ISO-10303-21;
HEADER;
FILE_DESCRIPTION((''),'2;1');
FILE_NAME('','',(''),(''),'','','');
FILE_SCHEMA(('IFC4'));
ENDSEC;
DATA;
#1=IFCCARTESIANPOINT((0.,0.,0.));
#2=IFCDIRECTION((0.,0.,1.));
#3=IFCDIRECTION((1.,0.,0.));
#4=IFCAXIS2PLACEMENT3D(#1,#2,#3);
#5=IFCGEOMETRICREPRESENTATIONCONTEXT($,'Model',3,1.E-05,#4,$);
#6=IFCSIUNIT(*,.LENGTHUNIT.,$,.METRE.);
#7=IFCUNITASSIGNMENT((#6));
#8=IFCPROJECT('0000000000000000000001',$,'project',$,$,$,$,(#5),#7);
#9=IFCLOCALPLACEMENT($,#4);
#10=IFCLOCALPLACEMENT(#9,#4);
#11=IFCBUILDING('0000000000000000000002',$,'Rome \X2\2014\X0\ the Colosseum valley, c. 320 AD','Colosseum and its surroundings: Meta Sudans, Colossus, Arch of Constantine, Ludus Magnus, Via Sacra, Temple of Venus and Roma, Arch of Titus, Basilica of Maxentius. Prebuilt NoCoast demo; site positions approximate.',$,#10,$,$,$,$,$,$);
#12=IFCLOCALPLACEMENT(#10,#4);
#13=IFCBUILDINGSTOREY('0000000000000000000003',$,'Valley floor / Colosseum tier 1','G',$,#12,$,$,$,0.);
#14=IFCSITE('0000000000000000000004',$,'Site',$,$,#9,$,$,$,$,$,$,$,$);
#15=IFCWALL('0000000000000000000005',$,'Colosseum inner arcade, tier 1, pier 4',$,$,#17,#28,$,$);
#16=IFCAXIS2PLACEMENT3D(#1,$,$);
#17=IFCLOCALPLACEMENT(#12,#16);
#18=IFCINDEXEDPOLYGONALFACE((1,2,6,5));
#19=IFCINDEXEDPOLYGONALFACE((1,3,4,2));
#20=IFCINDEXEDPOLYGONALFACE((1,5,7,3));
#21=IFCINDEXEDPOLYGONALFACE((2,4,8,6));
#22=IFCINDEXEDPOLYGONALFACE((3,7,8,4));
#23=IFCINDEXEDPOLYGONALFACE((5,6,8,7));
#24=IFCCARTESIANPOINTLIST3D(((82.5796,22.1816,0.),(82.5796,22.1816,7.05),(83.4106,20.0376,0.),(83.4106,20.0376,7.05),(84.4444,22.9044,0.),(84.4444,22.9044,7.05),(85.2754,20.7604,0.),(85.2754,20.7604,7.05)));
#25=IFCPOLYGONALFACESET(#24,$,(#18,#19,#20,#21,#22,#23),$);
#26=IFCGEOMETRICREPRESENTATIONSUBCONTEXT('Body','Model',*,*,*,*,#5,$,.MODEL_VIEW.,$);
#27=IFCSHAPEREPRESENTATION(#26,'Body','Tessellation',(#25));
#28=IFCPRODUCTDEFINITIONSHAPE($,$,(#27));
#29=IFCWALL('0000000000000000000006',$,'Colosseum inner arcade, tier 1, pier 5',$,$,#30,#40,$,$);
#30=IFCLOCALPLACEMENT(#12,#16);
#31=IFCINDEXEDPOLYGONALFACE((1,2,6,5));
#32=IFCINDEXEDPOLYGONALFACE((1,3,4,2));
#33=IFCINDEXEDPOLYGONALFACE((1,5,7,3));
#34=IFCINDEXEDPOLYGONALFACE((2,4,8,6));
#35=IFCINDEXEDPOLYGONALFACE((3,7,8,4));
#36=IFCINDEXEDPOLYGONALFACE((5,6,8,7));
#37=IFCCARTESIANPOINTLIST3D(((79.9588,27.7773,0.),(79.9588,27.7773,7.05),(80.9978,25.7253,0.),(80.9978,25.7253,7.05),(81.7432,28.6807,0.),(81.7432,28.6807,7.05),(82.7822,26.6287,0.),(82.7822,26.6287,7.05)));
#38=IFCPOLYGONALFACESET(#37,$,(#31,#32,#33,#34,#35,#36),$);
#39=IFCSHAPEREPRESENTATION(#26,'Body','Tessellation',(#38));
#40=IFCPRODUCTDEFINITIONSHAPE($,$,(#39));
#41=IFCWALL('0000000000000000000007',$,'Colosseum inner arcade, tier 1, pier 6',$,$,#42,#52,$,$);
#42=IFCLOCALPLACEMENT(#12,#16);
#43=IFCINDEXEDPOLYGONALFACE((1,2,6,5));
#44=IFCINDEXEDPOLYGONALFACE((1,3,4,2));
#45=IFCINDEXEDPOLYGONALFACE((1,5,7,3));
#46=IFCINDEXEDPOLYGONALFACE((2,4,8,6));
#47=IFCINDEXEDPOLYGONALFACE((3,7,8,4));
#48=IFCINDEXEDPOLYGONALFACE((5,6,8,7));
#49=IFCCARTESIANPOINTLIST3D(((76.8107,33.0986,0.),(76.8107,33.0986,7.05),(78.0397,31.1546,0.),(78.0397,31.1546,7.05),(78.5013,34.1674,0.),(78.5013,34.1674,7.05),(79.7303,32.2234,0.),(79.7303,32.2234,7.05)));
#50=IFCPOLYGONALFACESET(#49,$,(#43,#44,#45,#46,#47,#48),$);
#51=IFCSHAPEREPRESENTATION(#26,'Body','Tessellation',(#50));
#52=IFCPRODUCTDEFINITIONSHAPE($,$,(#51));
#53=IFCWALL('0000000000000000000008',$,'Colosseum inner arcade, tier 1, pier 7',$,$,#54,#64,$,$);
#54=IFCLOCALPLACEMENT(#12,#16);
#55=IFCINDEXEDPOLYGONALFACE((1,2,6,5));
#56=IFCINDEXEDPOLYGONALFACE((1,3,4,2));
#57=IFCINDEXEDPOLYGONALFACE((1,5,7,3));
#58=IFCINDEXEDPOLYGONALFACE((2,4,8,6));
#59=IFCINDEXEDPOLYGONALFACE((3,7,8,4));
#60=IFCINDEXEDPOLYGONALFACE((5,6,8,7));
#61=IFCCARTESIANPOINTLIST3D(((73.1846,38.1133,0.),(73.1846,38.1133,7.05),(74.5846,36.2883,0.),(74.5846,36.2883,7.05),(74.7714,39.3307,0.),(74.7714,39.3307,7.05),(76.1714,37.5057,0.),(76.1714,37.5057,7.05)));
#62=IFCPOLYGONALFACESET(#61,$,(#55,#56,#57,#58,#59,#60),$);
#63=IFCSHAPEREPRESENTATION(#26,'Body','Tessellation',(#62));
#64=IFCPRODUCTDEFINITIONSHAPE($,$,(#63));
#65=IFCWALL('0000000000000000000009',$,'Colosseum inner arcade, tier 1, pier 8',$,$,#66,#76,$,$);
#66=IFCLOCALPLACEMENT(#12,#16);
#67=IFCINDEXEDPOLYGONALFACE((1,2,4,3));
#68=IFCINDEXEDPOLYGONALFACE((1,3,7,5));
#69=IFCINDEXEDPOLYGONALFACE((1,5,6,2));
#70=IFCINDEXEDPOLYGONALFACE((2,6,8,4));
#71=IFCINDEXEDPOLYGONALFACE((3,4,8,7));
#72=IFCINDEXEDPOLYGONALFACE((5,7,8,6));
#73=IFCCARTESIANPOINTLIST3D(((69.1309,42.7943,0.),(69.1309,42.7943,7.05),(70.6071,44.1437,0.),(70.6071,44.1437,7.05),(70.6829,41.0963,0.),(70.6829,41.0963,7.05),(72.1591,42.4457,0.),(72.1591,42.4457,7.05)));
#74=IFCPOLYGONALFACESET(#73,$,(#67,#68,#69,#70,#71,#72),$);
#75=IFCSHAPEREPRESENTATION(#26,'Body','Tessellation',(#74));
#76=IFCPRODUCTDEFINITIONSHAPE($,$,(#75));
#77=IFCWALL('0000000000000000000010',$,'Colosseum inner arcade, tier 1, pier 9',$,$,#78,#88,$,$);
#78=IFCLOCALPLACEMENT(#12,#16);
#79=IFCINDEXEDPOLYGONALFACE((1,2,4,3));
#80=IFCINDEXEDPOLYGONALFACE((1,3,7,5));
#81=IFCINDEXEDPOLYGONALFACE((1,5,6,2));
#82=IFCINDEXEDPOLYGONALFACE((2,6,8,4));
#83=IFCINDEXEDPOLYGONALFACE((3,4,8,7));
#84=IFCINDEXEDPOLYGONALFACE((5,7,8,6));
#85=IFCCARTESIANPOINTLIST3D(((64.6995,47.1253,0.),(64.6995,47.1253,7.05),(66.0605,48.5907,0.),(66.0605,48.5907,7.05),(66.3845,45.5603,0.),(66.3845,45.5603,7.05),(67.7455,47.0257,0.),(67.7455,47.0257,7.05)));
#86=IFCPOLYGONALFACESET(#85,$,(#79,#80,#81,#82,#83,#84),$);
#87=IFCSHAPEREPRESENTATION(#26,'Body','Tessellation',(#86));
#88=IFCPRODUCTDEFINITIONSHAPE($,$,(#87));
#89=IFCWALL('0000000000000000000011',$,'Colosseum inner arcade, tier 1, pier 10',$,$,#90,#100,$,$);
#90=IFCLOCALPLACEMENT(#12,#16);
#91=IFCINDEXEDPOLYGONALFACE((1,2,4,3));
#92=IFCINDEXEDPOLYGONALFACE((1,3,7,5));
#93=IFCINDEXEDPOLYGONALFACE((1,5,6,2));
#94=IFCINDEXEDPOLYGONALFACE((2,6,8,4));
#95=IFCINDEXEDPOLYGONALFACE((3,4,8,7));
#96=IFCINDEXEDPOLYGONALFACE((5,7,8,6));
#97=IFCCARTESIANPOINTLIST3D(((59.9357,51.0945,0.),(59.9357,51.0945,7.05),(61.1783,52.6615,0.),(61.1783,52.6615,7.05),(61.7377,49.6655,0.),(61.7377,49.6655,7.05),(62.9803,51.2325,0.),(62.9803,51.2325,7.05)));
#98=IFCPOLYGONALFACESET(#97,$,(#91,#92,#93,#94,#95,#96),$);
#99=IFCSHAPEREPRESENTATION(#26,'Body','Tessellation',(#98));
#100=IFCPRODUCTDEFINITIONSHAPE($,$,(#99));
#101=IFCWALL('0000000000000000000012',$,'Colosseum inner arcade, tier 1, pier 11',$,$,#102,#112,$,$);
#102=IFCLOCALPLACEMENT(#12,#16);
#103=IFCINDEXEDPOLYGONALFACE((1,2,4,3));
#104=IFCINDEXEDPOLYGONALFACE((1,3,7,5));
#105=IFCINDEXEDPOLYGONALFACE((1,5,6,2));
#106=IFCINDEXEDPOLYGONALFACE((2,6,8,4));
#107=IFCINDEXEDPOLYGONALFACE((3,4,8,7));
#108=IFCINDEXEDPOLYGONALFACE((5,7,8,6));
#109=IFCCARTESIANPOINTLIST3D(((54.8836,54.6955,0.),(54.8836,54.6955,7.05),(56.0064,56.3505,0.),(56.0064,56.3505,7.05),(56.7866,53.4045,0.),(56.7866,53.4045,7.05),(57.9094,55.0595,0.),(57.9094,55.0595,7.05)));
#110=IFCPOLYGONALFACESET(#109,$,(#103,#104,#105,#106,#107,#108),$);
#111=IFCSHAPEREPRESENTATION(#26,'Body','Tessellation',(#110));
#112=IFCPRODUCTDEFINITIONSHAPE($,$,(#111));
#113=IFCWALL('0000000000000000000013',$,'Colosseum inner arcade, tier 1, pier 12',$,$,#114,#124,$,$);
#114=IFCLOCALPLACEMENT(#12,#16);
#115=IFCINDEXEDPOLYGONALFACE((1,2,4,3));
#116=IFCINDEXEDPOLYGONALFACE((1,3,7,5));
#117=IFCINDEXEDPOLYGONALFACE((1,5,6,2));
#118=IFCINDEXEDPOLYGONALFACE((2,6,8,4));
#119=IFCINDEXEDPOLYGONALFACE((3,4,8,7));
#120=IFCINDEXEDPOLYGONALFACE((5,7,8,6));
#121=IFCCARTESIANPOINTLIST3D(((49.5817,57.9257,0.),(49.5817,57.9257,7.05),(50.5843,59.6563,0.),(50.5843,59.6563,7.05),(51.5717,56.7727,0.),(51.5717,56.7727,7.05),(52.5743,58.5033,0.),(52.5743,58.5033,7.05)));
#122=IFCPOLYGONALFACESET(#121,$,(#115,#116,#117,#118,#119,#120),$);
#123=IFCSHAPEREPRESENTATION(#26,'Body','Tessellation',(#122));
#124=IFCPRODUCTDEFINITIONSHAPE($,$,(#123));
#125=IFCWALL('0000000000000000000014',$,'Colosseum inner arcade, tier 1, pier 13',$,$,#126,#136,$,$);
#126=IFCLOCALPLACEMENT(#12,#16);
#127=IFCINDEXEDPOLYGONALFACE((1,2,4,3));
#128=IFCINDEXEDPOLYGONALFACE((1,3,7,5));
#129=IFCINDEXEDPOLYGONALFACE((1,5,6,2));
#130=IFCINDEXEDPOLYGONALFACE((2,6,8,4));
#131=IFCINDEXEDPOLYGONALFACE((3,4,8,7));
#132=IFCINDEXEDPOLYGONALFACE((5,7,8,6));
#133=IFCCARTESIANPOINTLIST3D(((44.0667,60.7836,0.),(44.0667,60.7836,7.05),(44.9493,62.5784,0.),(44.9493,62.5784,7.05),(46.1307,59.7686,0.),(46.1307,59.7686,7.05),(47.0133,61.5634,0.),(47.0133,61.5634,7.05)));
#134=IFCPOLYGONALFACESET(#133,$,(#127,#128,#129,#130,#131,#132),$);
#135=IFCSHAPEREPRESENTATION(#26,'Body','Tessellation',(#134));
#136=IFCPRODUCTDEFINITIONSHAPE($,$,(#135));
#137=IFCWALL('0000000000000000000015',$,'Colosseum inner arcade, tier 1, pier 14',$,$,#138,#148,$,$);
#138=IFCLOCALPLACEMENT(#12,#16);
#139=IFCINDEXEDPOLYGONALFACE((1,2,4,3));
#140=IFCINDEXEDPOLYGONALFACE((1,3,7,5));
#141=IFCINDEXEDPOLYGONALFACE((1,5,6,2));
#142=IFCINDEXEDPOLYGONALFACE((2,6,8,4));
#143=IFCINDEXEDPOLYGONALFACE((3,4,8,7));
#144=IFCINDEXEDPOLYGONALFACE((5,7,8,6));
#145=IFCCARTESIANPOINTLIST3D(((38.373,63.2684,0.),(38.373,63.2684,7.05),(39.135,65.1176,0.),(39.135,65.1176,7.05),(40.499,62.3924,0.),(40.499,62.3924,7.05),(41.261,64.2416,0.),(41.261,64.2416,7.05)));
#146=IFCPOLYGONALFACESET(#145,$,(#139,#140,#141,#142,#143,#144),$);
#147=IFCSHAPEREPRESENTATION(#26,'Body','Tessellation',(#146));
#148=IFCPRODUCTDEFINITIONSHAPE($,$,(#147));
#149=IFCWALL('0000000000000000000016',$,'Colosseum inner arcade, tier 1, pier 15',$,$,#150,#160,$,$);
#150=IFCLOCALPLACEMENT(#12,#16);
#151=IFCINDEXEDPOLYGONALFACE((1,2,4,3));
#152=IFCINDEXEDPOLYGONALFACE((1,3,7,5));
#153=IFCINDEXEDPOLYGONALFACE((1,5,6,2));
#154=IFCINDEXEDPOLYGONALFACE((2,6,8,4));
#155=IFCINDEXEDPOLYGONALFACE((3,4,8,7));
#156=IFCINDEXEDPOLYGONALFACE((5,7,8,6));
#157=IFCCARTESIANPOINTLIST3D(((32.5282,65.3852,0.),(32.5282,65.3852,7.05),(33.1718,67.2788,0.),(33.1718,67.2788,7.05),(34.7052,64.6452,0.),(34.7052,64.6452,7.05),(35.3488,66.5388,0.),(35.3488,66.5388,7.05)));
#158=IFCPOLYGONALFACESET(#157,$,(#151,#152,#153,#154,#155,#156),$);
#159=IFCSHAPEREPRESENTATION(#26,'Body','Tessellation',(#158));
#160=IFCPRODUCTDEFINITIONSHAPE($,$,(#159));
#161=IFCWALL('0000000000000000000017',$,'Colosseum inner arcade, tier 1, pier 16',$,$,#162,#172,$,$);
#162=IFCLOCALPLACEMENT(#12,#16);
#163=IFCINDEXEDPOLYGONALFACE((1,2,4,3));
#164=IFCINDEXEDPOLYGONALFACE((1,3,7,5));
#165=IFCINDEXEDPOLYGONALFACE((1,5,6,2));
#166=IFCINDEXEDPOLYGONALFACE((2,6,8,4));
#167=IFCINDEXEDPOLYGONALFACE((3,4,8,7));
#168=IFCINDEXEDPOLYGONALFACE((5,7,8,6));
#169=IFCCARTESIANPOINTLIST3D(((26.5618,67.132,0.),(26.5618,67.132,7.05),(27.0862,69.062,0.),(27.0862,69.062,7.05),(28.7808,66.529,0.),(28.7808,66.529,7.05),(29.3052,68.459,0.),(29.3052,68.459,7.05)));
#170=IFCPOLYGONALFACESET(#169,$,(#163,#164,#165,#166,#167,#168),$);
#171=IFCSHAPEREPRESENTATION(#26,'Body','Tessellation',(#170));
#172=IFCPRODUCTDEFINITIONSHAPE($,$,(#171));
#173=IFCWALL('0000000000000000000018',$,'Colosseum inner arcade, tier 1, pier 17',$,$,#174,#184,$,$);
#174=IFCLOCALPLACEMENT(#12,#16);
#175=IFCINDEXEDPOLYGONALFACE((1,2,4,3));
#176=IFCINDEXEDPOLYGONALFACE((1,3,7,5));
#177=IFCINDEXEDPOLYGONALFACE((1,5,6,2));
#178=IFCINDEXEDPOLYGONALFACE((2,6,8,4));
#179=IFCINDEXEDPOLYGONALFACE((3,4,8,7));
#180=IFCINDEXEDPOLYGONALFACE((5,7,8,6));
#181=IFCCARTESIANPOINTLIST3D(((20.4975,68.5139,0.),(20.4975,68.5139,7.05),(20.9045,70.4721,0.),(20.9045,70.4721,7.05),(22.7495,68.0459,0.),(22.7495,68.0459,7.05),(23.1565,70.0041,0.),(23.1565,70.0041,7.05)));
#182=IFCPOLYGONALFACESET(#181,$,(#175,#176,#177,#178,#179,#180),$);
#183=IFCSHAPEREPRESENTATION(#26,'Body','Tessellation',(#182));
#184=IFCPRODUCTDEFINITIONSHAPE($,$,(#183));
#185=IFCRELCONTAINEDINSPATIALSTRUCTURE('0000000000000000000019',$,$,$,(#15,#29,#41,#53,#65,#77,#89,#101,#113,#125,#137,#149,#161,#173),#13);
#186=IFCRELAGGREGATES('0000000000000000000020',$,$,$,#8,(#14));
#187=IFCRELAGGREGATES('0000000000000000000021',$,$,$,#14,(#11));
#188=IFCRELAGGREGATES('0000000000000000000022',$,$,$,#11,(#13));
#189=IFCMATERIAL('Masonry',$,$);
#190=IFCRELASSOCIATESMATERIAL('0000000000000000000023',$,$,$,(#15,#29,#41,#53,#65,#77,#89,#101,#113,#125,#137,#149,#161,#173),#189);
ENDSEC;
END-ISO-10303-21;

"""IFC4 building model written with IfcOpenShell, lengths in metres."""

from ifc_helpers import new_model, si_unit, frame, origin_with_axes, place, context, subcontext, project, spatial, indexed_curve, outline, extrude, material, element, save


model = new_model("IFC4")

# Units and contexts
model_context = context("Model", 3, precision=1e-05, world=origin_with_axes())
body_context = subcontext(model_context, "Body", "Model", "MODEL_VIEW")
ifc_project = project(units=[si_unit("LENGTHUNIT", "METRE")], contexts=[model_context])

# Site, building, storey
site_placement = place(None, origin_with_axes())
site = spatial("IfcSite", under=ifc_project, at=site_placement, Name="Site")
building_placement = place(site_placement, origin_with_axes())
building = spatial("IfcBuilding", under=site, at=building_placement, Name="Rome — the Colosseum valley, c. 320 AD", Description="Colosseum and its surroundings: Meta Sudans, Colossus, Arch of Constantine, Ludus Magnus, Via Sacra, Temple of Venus and Roma, Arch of Titus, Basilica of Maxentius. Prebuilt NoCoast demo; site positions approximate.")
storey_placement = place(building_placement, origin_with_axes())
storey = spatial("IfcBuildingStorey", under=building, at=storey_placement, Name="Valley floor / Colosseum tier 1", Description="G", Elevation=0.0)

# Walls
ifc_material = material(Name="Masonry")
wall_1_placement = place(storey_placement, frame((84.343, 20.399, 0.0), z_axis=(0.0, 0.0, 1.0), x_axis=(-0.361397, 0.932412, 0.0)))
element("IfcWall", 1, at=wall_1_placement, inside=storey, material=ifc_material, Name="Colosseum inner arcade, tier 1, pier 4", context=body_context, shape_type="SweptSolid", body=[
    extrude(outline(indexed_curve([(0.0, 0.0), (0.0, 2.0), (2.2994, 2.0), (2.2994, 0.0), (0.0, 0.0)], self_intersect=False)), frame((0.0, -1.0, 0.0), z_axis=(0.0, 0.0, 1.0), x_axis=(1.0, 0.0, 0.0)), (0.0, 0.0, 1.0), 7.05),
])
wall_2_placement = place(storey_placement, frame((81.89, 26.177, 0.0), z_axis=(0.0, 0.0, 1.0), x_axis=(-0.45173, 0.892155, 0.0)))
element("IfcWall", 2, at=wall_2_placement, inside=storey, material=ifc_material, Name="Colosseum inner arcade, tier 1, pier 5", context=body_context, shape_type="SweptSolid", body=[
    extrude(outline(indexed_curve([(0.0, 0.0), (0.0, 2.0), (2.3, 2.0), (2.3, 0.0), (0.0, 0.0)], self_intersect=False)), frame((0.0, -1.0, 0.0), z_axis=(0.0, 0.0, 1.0), x_axis=(1.0, 0.0, 0.0)), (0.0, 0.0, 1.0), 7.05),
])
wall_3_placement = place(storey_placement, frame((78.885, 31.689, 0.0), z_axis=(0.0, 0.0, 1.0), x_axis=(-0.534369, 0.845251, 0.0)))
element("IfcWall", 3, at=wall_3_placement, inside=storey, material=ifc_material, Name="Colosseum inner arcade, tier 1, pier 6", context=body_context, shape_type="SweptSolid", body=[
    extrude(outline(indexed_curve([(0.0, 0.0), (0.0, 2.0), (2.2999, 2.0), (2.2999, 0.0), (0.0, 0.0)], self_intersect=False)), frame((0.0, -1.0, 0.0), z_axis=(0.0, 0.0, 1.0), x_axis=(1.0, 0.0, 0.0)), (0.0, 0.0, 1.0), 7.05),
])
wall_4_placement = place(storey_placement, frame((75.378, 36.897, 0.0), z_axis=(0.0, 0.0, 1.0), x_axis=(-0.60866, 0.793431, 0.0)))
element("IfcWall", 4, at=wall_4_placement, inside=storey, material=ifc_material, Name="Colosseum inner arcade, tier 1, pier 7", context=body_context, shape_type="SweptSolid", body=[
    extrude(outline(indexed_curve([(0.0, 0.0), (0.0, 2.0), (2.3001, 2.0), (2.3001, 0.0), (0.0, 0.0)], self_intersect=False)), frame((0.0, -1.0, 0.0), z_axis=(0.0, 0.0, 1.0), x_axis=(1.0, 0.0, 0.0)), (0.0, 0.0, 1.0), 7.05),
])
wall_5_placement = place(storey_placement, frame((71.421, 41.771, 0.0), z_axis=(0.0, 0.0, 1.0), x_axis=(-0.674661, 0.738128, 0.0)))
element("IfcWall", 5, at=wall_5_placement, inside=storey, material=ifc_material, Name="Colosseum inner arcade, tier 1, pier 8", context=body_context, shape_type="SweptSolid", body=[
    extrude(outline(indexed_curve([(0.0, 0.0), (0.0, 2.0), (2.3004, 2.0), (2.3004, 0.0), (0.0, 0.0)], self_intersect=False)), frame((0.0, -1.0, 0.0), z_axis=(0.0, 0.0, 1.0), x_axis=(1.0, 0.0, 0.0)), (0.0, 0.0, 1.0), 7.05),
])
wall_6_placement = place(storey_placement, frame((67.065, 46.293, 0.0), z_axis=(0.0, 0.0, 1.0), x_axis=(-0.732716, 0.680534, 0.0)))
element("IfcWall", 6, at=wall_6_placement, inside=storey, material=ifc_material, Name="Colosseum inner arcade, tier 1, pier 9", context=body_context, shape_type="SweptSolid", body=[
    extrude(outline(indexed_curve([(0.0, 0.0), (0.0, 2.0), (2.2997, 2.0), (2.2997, 0.0), (0.0, 0.0)], self_intersect=False)), frame((0.0, -1.0, 0.0), z_axis=(0.0, 0.0, 1.0), x_axis=(1.0, 0.0, 0.0)), (0.0, 0.0, 1.0), 7.05),
])
wall_7_placement = place(storey_placement, frame((62.359, 50.449, 0.0), z_axis=(0.0, 0.0, 1.0), x_axis=(-0.783534, 0.621349, 0.0)))
element("IfcWall", 7, at=wall_7_placement, inside=storey, material=ifc_material, Name="Colosseum inner arcade, tier 1, pier 10", context=body_context, shape_type="SweptSolid", body=[
    extrude(outline(indexed_curve([(0.0, 0.0), (0.0, 2.0), (2.2998, 2.0), (2.2998, 0.0), (0.0, 0.0)], self_intersect=False)), frame((0.0, -1.0, 0.0), z_axis=(0.0, 0.0, 1.0), x_axis=(1.0, 0.0, 0.0)), (0.0, 0.0, 1.0), 7.05),
])
wall_8_placement = place(storey_placement, frame((57.348, 54.232, 0.0), z_axis=(0.0, 0.0, 1.0), x_axis=(-0.827541, 0.561406, 0.0)))
element("IfcWall", 8, at=wall_8_placement, inside=storey, material=ifc_material, Name="Colosseum inner arcade, tier 1, pier 11", context=body_context, shape_type="SweptSolid", body=[
    extrude(outline(indexed_curve([(0.0, 0.0), (0.0, 2.0), (2.2996, 2.0), (2.2996, 0.0), (0.0, 0.0)], self_intersect=False)), frame((0.0, -1.0, 0.0), z_axis=(0.0, 0.0, 1.0), x_axis=(1.0, 0.0, 0.0)), (0.0, 0.0, 1.0), 7.05),
])
wall_9_placement = place(storey_placement, frame((52.073, 57.638, 0.0), z_axis=(0.0, 0.0, 1.0), x_axis=(-0.865258, 0.501328, 0.0)))
element("IfcWall", 9, at=wall_9_placement, inside=storey, material=ifc_material, Name="Colosseum inner arcade, tier 1, pier 12", context=body_context, shape_type="SweptSolid", body=[
    extrude(outline(indexed_curve([(0.0, 0.0), (0.0, 2.0), (2.2999, 2.0), (2.2999, 0.0), (0.0, 0.0)], self_intersect=False)), frame((0.0, -1.0, 0.0), z_axis=(0.0, 0.0, 1.0), x_axis=(1.0, 0.0, 0.0)), (0.0, 0.0, 1.0), 7.05),
])
wall_10_placement = place(storey_placement, frame((46.572, 60.666, 0.0), z_axis=(0.0, 0.0, 1.0), x_axis=(-0.897364, 0.441291, 0.0)))
element("IfcWall", 10, at=wall_10_placement, inside=storey, material=ifc_material, Name="Colosseum inner arcade, tier 1, pier 13", context=body_context, shape_type="SweptSolid", body=[
    extrude(outline(indexed_curve([(0.0, 0.0), (0.0, 2.0), (2.3001, 2.0), (2.3001, 0.0), (0.0, 0.0)], self_intersect=False)), frame((0.0, -1.0, 0.0), z_axis=(0.0, 0.0, 1.0), x_axis=(1.0, 0.0, 0.0)), (0.0, 0.0, 1.0), 7.05),
])
wall_11_placement = place(storey_placement, frame((40.88, 63.317, 0.0), z_axis=(0.0, 0.0, 1.0), x_axis=(-0.924588, 0.380969, 0.0)))
element("IfcWall", 11, at=wall_11_placement, inside=storey, material=ifc_material, Name="Colosseum inner arcade, tier 1, pier 14", context=body_context, shape_type="SweptSolid", body=[
    extrude(outline(indexed_curve([(0.0, 0.0), (0.0, 2.0), (2.2994, 2.0), (2.2994, 0.0), (0.0, 0.0)], self_intersect=False)), frame((0.0, -1.0, 0.0), z_axis=(0.0, 0.0, 1.0), x_axis=(1.0, 0.0, 0.0)), (0.0, 0.0, 1.0), 7.05),
])
wall_12_placement = place(storey_placement, frame((35.027, 65.592, 0.0), z_axis=(0.0, 0.0, 1.0), x_axis=(-0.946797, 0.321833, 0.0)))
element("IfcWall", 12, at=wall_12_placement, inside=storey, material=ifc_material, Name="Colosseum inner arcade, tier 1, pier 15", context=body_context, shape_type="SweptSolid", body=[
    extrude(outline(indexed_curve([(0.0, 0.0), (0.0, 2.0), (2.2993, 2.0), (2.2993, 0.0), (0.0, 0.0)], self_intersect=False)), frame((0.0, -1.0, 0.0), z_axis=(0.0, 0.0, 1.0), x_axis=(1.0, 0.0, 0.0)), (0.0, 0.0, 1.0), 7.05),
])
wall_13_placement = place(storey_placement, frame((29.043, 67.494, 0.0), z_axis=(0.0, 0.0, 1.0), x_axis=(-0.965004, 0.262234, 0.0)))
element("IfcWall", 13, at=wall_13_placement, inside=storey, material=ifc_material, Name="Colosseum inner arcade, tier 1, pier 16", context=body_context, shape_type="SweptSolid", body=[
    extrude(outline(indexed_curve([(0.0, 0.0), (0.0, 2.0), (2.2995, 2.0), (2.2995, 0.0), (0.0, 0.0)], self_intersect=False)), frame((0.0, -1.0, 0.0), z_axis=(0.0, 0.0, 1.0), x_axis=(1.0, 0.0, 0.0)), (0.0, 0.0, 1.0), 7.05),
])
wall_14_placement = place(storey_placement, frame((22.953, 69.025, 0.0), z_axis=(0.0, 0.0, 1.0), x_axis=(-0.979082, 0.203468, 0.0)))
element("IfcWall", 14, at=wall_14_placement, inside=storey, material=ifc_material, Name="Colosseum inner arcade, tier 1, pier 17", context=body_context, shape_type="SweptSolid", body=[
    extrude(outline(indexed_curve([(0.0, 0.0), (0.0, 2.0), (2.3001, 2.0), (2.3001, 0.0), (0.0, 0.0)], self_intersect=False)), frame((0.0, -1.0, 0.0), z_axis=(0.0, 0.0, 1.0), x_axis=(1.0, 0.0, 0.0)), (0.0, 0.0, 1.0), 7.05),
])

save(model, "model.ifc")
